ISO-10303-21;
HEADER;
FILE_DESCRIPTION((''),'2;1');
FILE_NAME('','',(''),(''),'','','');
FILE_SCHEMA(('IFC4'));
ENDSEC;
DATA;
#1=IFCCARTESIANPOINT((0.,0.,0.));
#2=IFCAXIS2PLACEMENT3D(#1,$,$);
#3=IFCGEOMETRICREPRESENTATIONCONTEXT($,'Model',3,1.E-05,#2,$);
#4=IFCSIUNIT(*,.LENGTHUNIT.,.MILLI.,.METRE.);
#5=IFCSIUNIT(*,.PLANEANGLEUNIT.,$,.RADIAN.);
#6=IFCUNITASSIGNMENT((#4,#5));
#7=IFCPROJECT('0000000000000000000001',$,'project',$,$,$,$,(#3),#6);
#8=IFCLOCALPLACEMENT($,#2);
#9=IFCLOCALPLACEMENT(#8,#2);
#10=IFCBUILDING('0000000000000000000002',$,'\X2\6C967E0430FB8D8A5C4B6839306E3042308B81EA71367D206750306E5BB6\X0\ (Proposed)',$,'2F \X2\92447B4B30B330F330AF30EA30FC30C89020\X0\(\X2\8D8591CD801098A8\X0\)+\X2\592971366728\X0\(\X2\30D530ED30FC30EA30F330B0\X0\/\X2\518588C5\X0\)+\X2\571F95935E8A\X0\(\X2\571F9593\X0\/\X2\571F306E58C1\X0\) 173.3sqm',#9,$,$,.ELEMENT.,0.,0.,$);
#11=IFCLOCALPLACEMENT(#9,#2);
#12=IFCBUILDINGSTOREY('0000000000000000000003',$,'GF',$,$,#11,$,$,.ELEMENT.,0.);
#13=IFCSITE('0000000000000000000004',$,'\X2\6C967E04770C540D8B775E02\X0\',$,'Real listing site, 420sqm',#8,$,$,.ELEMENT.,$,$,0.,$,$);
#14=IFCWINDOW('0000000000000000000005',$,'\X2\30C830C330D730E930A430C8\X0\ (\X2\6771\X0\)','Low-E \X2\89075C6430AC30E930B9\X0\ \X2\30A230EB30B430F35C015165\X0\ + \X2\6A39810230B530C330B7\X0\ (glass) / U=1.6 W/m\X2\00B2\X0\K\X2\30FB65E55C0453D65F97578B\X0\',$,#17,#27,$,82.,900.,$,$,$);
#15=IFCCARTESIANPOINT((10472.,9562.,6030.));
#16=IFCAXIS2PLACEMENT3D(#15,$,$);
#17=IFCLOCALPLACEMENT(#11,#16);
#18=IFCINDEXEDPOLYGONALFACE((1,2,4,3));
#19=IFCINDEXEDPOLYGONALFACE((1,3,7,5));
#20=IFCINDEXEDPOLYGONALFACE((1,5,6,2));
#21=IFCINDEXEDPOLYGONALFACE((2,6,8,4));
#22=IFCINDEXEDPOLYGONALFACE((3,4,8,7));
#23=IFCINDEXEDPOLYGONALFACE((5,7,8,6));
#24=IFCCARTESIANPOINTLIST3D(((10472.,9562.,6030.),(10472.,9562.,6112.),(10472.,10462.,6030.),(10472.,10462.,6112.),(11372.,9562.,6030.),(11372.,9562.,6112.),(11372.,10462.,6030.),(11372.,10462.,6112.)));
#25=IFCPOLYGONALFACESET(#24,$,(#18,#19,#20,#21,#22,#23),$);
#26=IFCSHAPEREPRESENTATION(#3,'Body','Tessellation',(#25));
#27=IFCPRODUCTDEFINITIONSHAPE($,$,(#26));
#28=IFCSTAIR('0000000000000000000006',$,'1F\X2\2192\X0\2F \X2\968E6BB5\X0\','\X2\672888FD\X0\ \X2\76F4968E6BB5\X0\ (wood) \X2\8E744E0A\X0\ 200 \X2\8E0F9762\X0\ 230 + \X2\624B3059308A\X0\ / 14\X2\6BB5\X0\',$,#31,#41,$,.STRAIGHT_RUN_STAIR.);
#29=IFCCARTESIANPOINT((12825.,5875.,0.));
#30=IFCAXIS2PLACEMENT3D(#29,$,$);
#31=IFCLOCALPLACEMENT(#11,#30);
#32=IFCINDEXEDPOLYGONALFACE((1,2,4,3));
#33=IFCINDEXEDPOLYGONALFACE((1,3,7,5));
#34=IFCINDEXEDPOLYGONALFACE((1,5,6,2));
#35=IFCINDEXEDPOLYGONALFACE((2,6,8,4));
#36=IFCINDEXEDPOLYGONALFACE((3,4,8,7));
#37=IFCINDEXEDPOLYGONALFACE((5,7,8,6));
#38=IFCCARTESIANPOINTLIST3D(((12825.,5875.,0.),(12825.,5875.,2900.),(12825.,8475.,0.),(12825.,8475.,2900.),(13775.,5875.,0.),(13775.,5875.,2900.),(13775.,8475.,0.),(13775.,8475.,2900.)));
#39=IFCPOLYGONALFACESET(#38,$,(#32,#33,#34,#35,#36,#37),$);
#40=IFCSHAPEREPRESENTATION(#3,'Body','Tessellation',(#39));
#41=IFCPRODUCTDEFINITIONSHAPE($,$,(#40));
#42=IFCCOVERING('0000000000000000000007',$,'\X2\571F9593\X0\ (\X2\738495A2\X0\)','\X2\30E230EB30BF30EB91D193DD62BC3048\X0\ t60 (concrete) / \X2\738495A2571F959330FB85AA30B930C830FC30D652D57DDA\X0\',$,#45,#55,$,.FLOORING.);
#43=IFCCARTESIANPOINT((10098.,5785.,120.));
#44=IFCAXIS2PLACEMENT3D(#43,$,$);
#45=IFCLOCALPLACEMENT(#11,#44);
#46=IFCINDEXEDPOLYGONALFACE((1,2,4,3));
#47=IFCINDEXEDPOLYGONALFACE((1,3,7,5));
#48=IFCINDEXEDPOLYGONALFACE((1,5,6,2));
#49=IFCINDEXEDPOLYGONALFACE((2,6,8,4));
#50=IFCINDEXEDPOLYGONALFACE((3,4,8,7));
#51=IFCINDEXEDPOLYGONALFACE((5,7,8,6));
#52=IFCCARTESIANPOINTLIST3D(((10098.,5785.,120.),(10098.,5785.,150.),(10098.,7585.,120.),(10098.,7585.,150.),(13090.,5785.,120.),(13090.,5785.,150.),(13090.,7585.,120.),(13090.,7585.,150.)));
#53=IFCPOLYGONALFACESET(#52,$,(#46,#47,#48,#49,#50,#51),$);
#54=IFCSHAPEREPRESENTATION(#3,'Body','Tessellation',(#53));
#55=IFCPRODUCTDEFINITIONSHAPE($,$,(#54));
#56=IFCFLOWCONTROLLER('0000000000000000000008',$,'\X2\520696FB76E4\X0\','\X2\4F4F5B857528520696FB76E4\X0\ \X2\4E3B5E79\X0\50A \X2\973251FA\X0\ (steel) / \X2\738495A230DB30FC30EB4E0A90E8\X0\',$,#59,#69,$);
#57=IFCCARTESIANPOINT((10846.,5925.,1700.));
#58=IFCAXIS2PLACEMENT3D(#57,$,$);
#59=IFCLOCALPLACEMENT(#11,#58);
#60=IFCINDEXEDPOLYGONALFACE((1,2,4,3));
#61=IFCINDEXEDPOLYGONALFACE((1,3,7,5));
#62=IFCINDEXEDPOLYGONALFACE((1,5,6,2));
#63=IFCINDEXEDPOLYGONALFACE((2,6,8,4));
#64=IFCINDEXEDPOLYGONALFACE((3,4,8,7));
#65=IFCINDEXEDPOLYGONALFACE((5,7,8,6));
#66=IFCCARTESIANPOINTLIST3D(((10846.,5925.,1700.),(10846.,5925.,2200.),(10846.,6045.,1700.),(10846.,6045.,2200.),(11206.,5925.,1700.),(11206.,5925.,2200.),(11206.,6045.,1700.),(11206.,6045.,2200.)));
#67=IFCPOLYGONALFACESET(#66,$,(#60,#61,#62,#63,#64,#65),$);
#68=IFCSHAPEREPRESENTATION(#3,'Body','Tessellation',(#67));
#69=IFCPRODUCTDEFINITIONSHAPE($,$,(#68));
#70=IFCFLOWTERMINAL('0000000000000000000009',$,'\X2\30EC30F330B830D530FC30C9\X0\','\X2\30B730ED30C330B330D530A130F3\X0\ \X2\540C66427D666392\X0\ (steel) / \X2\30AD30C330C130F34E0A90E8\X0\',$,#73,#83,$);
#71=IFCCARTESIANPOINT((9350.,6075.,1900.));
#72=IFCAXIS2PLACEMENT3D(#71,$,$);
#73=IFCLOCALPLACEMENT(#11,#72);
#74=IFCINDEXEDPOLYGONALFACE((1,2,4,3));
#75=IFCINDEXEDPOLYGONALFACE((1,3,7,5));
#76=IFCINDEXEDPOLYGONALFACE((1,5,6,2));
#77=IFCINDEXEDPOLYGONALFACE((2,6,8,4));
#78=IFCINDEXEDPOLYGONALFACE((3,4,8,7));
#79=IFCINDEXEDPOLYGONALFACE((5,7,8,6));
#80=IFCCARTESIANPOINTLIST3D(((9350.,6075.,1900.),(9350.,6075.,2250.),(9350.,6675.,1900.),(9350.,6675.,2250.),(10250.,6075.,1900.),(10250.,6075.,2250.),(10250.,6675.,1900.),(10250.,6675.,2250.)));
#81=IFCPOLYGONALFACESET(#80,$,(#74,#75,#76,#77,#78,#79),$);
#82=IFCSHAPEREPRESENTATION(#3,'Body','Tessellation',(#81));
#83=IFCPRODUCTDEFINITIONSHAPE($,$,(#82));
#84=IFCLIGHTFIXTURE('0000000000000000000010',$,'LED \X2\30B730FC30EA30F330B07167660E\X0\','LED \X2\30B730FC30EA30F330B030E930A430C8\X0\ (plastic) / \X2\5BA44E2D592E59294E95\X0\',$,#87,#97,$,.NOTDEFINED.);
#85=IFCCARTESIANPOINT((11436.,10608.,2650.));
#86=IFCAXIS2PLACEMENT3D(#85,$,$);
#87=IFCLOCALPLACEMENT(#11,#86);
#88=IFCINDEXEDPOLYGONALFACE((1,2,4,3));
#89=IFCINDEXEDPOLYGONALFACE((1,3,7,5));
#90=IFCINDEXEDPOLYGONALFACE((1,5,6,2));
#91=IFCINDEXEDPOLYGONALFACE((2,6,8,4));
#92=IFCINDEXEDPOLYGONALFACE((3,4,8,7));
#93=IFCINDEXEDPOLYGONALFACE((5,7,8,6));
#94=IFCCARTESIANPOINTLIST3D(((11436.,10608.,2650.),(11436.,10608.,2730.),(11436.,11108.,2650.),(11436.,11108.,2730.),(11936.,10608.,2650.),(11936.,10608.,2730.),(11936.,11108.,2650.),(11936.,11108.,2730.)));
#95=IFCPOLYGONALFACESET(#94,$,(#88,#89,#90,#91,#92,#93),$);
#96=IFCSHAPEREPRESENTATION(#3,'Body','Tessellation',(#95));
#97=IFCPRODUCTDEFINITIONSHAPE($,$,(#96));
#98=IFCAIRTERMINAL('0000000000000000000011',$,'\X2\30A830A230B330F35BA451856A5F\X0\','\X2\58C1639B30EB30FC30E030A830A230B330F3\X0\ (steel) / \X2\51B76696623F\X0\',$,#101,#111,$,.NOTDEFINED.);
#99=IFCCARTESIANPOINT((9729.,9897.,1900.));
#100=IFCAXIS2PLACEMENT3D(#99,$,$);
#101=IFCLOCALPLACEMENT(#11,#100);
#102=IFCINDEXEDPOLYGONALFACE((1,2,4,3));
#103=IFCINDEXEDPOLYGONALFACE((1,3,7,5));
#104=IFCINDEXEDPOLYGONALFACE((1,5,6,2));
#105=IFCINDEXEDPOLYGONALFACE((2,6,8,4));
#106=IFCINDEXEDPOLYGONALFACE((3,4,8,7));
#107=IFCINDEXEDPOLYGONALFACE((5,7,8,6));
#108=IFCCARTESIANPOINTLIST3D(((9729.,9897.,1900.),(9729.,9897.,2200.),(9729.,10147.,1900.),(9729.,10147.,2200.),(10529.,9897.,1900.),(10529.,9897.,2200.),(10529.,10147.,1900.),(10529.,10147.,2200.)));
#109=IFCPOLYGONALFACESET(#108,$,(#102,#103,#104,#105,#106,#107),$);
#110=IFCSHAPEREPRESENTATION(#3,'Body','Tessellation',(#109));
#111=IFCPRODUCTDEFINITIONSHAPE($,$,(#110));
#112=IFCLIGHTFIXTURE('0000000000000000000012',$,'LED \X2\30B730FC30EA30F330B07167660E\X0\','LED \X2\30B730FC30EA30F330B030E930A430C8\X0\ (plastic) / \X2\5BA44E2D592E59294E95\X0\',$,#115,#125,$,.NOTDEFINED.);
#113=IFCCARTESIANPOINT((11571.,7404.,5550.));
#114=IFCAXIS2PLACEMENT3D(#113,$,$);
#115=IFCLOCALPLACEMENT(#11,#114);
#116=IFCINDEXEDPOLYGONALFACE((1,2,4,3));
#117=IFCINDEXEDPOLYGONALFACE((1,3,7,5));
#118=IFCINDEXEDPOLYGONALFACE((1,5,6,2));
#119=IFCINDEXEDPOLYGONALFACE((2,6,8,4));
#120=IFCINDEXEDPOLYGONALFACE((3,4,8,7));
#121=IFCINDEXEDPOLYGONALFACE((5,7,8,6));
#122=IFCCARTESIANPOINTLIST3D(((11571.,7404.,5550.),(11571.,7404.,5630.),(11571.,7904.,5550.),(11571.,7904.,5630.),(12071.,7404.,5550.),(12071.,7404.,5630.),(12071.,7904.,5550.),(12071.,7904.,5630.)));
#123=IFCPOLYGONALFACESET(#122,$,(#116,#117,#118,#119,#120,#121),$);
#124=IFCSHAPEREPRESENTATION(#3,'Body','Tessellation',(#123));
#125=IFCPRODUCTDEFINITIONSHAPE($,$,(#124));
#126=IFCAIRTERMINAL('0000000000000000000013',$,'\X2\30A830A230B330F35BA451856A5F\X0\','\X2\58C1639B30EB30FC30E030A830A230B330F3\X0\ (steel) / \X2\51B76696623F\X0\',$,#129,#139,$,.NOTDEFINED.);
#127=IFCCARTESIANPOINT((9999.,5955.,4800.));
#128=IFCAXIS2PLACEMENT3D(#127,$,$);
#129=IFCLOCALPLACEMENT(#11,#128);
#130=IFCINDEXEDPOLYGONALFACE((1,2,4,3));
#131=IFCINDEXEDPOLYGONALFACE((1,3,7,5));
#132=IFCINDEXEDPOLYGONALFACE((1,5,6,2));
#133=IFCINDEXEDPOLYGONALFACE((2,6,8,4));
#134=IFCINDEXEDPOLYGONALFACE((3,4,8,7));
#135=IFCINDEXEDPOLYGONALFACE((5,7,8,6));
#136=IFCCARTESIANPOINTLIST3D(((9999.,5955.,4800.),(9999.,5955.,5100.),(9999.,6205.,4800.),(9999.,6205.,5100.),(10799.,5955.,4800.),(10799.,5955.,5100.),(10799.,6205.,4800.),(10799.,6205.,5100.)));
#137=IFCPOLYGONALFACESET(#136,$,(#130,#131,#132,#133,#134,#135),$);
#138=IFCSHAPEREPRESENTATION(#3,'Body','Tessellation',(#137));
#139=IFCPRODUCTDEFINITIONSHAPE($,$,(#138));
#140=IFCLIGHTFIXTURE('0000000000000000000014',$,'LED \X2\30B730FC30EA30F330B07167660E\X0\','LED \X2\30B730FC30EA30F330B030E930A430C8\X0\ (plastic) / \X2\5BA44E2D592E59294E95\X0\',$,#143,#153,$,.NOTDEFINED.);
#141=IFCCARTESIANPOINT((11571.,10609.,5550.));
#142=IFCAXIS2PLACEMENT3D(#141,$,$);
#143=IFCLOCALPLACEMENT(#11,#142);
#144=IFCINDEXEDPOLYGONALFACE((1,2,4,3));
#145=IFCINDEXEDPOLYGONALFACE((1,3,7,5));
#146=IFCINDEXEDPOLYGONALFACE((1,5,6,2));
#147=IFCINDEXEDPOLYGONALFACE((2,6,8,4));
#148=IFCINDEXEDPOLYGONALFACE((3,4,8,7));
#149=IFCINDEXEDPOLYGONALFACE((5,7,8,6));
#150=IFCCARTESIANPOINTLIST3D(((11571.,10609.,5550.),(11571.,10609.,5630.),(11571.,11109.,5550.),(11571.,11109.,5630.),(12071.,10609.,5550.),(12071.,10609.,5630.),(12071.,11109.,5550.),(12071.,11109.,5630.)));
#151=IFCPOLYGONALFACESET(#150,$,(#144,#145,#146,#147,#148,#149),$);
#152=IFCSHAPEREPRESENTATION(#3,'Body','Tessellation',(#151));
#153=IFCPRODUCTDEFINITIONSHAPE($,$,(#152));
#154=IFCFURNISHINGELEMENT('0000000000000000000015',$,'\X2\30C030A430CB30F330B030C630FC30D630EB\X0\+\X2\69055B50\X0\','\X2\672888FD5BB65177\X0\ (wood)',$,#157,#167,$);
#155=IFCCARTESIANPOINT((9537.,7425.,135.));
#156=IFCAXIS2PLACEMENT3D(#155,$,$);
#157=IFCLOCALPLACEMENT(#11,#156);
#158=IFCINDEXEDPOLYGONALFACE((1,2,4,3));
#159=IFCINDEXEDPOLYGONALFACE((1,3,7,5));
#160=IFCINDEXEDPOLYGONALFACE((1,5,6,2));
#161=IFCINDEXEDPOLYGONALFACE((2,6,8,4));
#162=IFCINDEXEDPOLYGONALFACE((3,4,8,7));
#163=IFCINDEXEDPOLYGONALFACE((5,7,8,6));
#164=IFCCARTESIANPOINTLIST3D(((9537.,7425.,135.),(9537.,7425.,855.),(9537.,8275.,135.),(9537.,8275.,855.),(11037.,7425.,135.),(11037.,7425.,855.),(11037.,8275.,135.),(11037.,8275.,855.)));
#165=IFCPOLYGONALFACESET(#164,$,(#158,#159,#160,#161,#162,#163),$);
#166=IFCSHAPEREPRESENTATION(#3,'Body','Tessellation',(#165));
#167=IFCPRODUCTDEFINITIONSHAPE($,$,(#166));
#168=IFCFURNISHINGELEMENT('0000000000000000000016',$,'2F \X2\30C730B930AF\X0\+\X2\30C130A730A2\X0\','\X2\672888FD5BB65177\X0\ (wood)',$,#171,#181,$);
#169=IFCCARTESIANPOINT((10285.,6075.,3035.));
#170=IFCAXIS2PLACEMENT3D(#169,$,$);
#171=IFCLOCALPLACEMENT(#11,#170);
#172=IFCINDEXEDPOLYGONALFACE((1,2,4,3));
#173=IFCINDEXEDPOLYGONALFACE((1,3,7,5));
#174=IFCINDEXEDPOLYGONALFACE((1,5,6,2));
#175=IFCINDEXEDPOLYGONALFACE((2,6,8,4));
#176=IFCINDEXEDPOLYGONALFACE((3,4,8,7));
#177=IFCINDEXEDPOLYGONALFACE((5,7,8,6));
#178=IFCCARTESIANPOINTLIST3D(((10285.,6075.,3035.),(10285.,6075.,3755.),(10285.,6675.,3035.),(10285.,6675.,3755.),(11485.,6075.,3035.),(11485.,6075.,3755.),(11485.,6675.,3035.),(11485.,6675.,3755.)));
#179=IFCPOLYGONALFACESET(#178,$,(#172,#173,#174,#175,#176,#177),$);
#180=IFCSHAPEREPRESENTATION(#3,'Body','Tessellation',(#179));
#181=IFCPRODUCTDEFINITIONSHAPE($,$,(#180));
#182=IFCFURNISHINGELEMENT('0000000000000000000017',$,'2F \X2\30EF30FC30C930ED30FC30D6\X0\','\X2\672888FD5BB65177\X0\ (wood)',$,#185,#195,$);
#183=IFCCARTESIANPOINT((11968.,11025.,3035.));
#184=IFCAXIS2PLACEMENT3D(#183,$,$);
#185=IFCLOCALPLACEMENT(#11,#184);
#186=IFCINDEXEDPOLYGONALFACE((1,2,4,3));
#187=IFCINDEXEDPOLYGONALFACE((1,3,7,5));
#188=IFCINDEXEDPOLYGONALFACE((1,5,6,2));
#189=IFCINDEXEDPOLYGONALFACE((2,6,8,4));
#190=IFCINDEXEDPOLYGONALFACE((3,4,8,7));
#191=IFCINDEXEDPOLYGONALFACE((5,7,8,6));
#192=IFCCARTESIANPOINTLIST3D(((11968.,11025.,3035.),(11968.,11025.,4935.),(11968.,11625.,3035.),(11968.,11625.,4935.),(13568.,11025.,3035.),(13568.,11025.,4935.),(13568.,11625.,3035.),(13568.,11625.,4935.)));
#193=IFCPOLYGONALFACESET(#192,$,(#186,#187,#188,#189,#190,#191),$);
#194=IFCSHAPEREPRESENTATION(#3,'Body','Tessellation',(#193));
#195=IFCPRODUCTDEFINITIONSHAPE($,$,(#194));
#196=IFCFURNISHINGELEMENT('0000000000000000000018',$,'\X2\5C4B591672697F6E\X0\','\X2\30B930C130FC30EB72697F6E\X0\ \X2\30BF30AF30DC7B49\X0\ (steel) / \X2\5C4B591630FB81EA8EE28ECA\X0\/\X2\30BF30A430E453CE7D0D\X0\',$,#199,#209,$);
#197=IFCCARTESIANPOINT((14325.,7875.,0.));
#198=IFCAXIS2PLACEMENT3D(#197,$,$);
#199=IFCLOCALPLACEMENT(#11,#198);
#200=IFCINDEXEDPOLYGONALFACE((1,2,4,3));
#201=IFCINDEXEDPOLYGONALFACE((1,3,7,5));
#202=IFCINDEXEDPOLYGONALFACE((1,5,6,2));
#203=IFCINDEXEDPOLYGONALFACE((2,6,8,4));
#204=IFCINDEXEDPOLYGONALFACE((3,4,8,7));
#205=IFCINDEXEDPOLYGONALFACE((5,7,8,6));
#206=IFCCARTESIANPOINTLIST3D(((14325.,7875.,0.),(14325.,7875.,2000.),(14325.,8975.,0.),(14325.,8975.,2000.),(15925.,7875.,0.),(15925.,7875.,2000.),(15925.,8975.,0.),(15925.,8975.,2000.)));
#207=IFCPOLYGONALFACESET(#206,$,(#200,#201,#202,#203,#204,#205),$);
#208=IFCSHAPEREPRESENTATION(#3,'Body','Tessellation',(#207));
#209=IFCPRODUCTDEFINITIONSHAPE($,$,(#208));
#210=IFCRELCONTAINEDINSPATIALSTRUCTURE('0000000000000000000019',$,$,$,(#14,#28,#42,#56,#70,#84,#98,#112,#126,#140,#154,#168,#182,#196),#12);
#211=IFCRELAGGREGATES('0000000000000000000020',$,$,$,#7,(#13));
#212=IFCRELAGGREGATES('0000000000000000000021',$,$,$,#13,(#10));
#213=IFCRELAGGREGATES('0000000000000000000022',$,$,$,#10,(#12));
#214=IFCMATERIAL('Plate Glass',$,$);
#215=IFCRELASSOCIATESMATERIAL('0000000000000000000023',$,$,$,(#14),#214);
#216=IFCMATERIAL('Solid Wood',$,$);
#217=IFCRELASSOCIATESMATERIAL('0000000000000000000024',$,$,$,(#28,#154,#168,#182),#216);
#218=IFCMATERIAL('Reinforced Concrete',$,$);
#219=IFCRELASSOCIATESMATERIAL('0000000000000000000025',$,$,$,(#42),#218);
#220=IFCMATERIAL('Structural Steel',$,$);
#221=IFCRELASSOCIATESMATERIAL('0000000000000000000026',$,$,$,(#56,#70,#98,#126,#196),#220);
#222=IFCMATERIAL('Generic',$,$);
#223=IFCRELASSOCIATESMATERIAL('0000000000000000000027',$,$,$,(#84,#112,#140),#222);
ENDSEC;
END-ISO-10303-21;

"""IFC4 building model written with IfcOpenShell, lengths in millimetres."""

from ifc_helpers import new_model, si_unit, frame, frame_2d, origin, place, context, project, spatial, rectangle, extrude, material, element, save


model = new_model("IFC4")

# Units and contexts
model_context = context("Model", 3, precision=1e-05, world=origin())
ifc_project = project(units=[si_unit("LENGTHUNIT", "METRE", prefix="MILLI"), si_unit("PLANEANGLEUNIT", "RADIAN")], contexts=[model_context])

# Site, building, storey
site_placement = place(None, origin())
site = spatial("IfcSite", under=ifc_project, at=site_placement, Name="沖縄県名護市", ObjectType="Real listing site, 420sqm", CompositionType="ELEMENT", RefElevation=0.0)
building_placement = place(site_placement, origin())
building = spatial("IfcBuilding", under=site, at=building_placement, Name="沖縄・越屋根のある自然素材の家 (Proposed)", ObjectType="2F 鉄筋コンクリート造(超重耐風)+天然木(フローリング/内装)+土間床(土間/土の壁) 173.3sqm", CompositionType="ELEMENT", ElevationOfRefHeight=0.0, ElevationOfTerrain=0.0)
storey_placement = place(building_placement, origin())
storey = spatial("IfcBuildingStorey", under=building, at=storey_placement, Name="GF", CompositionType="ELEMENT", Elevation=0.0)

# Shared definitions
ifc_material_1 = material(Name="Solid Wood")

# Window
ifc_material_2 = material(Name="Plate Glass")
window_placement = place(storey_placement, frame((10472.0, 9562.0, 6030.0)))
element("IfcWindow", 1, at=window_placement, inside=storey, material=ifc_material_2, Name="トップライト (東)", Description="Low-E 複層ガラス アルゴン封入 + 樹脂サッシ (glass) / U=1.6 W/m²K・日射取得型", OverallHeight=82.0, OverallWidth=900.0, context=model_context, shape_type="SweptSolid", body=[
    extrude(rectangle(XDim=900.0, YDim=900.0, at=frame_2d((450.0, 450.0))), frame((10472.0, 9562.0, 6030.0)), (0.0, 0.0, 1.0), 82.0),
])

# Stair
stair_placement = place(storey_placement, frame((12825.0, 5875.0, 0.0)))
element("IfcStair", 2, at=stair_placement, inside=storey, material=ifc_material_1, Name="1F→2F 階段", Description="木製 直階段 (wood) 蹴上 200 踏面 230 + 手すり / 14段", PredefinedType="STRAIGHT_RUN_STAIR", context=model_context, shape_type="SweptSolid", body=[
    extrude(rectangle(XDim=950.0, YDim=2600.0, at=frame_2d((475.0, 1300.0))), frame((12825.0, 5875.0, 0.0)), (0.0, 0.0, 1.0), 2900.0),
])

# Covering
ifc_material_3 = material(Name="Reinforced Concrete")
covering_placement = place(storey_placement, frame((10098.0, 5785.0, 120.0)))
element("IfcCovering", 3, at=covering_placement, inside=storey, material=ifc_material_3, Name="土間 (玄関)", Description="モルタル金鏝押え t60 (concrete) / 玄関土間・薪ストーブ動線", PredefinedType="FLOORING", context=model_context, shape_type="SweptSolid", body=[
    extrude(rectangle(XDim=2992.0, YDim=1800.0, at=frame_2d((1496.0, 900.0))), frame((10098.0, 5785.0, 120.0)), (0.0, 0.0, 1.0), 30.0),
])

# Flow controller
ifc_material_4 = material(Name="Structural Steel")
flow_controller_placement = place(storey_placement, frame((10846.0, 5925.0, 1700.0)))
element("IfcFlowController", 4, at=flow_controller_placement, inside=storey, material=ifc_material_4, Name="分電盤", Description="住宅用分電盤 主幹50A 露出 (steel) / 玄関ホール上部", context=model_context, shape_type="SweptSolid", body=[
    extrude(rectangle(XDim=360.0, YDim=120.0, at=frame_2d((180.0, 60.0))), frame((10846.0, 5925.0, 1700.0)), (0.0, 0.0, 1.0), 500.0),
])

# Flow terminal
flow_terminal_placement = place(storey_placement, frame((9350.0, 6075.0, 1900.0)))
element("IfcFlowTerminal", 5, at=flow_terminal_placement, inside=storey, material=ifc_material_4, Name="レンジフード", Description="シロッコファン 同時給排 (steel) / キッチン上部", context=model_context, shape_type="SweptSolid", body=[
    extrude(rectangle(XDim=900.0, YDim=600.0, at=frame_2d((450.0, 300.0))), frame((9350.0, 6075.0, 1900.0)), (0.0, 0.0, 1.0), 350.0),
])

# Light fixture
ifc_material_5 = material(Name="Generic")
light_fixture_1_placement = place(storey_placement, frame((11436.0, 10608.0, 2650.0)))
element("IfcLightFixture", 6, at=light_fixture_1_placement, inside=storey, material=ifc_material_5, Name="LED シーリング照明", Description="LED シーリングライト (plastic) / 室中央天井", PredefinedType="NOTDEFINED", context=model_context, shape_type="SweptSolid", body=[
    extrude(rectangle(XDim=500.0, YDim=500.0, at=frame_2d((250.0, 250.0))), frame((11436.0, 10608.0, 2650.0)), (0.0, 0.0, 1.0), 80.0),
])

# Air terminal
air_terminal_1_placement = place(storey_placement, frame((9729.0, 9897.0, 1900.0)))
element("IfcAirTerminal", 7, at=air_terminal_1_placement, inside=storey, material=ifc_material_4, Name="エアコン室内機", Description="壁掛ルームエアコン (steel) / 冷暖房", PredefinedType="NOTDEFINED", context=model_context, shape_type="SweptSolid", body=[
    extrude(rectangle(XDim=800.0, YDim=250.0, at=frame_2d((400.0, 125.0))), frame((9729.0, 9897.0, 1900.0)), (0.0, 0.0, 1.0), 300.0),
])

# Light fixture
light_fixture_2_placement = place(storey_placement, frame((11571.0, 7404.0, 5550.0)))
element("IfcLightFixture", 8, at=light_fixture_2_placement, inside=storey, material=ifc_material_5, Name="LED シーリング照明", Description="LED シーリングライト (plastic) / 室中央天井", PredefinedType="NOTDEFINED", context=model_context, shape_type="SweptSolid", body=[
    extrude(rectangle(XDim=500.0, YDim=500.0, at=frame_2d((250.0, 250.0))), frame((11571.0, 7404.0, 5550.0)), (0.0, 0.0, 1.0), 80.0),
])

# Air terminal
air_terminal_2_placement = place(storey_placement, frame((9999.0, 5955.0, 4800.0)))
element("IfcAirTerminal", 9, at=air_terminal_2_placement, inside=storey, material=ifc_material_4, Name="エアコン室内機", Description="壁掛ルームエアコン (steel) / 冷暖房", PredefinedType="NOTDEFINED", context=model_context, shape_type="SweptSolid", body=[
    extrude(rectangle(XDim=800.0, YDim=250.0, at=frame_2d((400.0, 125.0))), frame((9999.0, 5955.0, 4800.0)), (0.0, 0.0, 1.0), 300.0),
])

# Light fixture
light_fixture_3_placement = place(storey_placement, frame((11571.0, 10609.0, 5550.0)))
element("IfcLightFixture", 10, at=light_fixture_3_placement, inside=storey, material=ifc_material_5, Name="LED シーリング照明", Description="LED シーリングライト (plastic) / 室中央天井", PredefinedType="NOTDEFINED", context=model_context, shape_type="SweptSolid", body=[
    extrude(rectangle(XDim=500.0, YDim=500.0, at=frame_2d((250.0, 250.0))), frame((11571.0, 10609.0, 5550.0)), (0.0, 0.0, 1.0), 80.0),
])

# Furnishing elements
furnishing_1_placement = place(storey_placement, frame((9537.0, 7425.0, 135.0)))
element("IfcFurnishingElement", 11, at=furnishing_1_placement, inside=storey, material=ifc_material_1, Name="ダイニングテーブル+椅子", Description="木製家具 (wood)", context=model_context, shape_type="SweptSolid", body=[
    extrude(rectangle(XDim=1500.0, YDim=850.0, at=frame_2d((750.0, 425.0))), frame((9537.0, 7425.0, 135.0)), (0.0, 0.0, 1.0), 720.0),
])
furnishing_2_placement = place(storey_placement, frame((10285.0, 6075.0, 3035.0)))
element("IfcFurnishingElement", 12, at=furnishing_2_placement, inside=storey, material=ifc_material_1, Name="2F デスク+チェア", Description="木製家具 (wood)", context=model_context, shape_type="SweptSolid", body=[
    extrude(rectangle(XDim=1200.0, YDim=600.0, at=frame_2d((600.0, 300.0))), frame((10285.0, 6075.0, 3035.0)), (0.0, 0.0, 1.0), 720.0),
])
furnishing_3_placement = place(storey_placement, frame((11968.0, 11025.0, 3035.0)))
element("IfcFurnishingElement", 13, at=furnishing_3_placement, inside=storey, material=ifc_material_1, Name="2F ワードローブ", Description="木製家具 (wood)", context=model_context, shape_type="SweptSolid", body=[
    extrude(rectangle(XDim=1600.0, YDim=600.0, at=frame_2d((800.0, 300.0))), frame((11968.0, 11025.0, 3035.0)), (0.0, 0.0, 1.0), 1900.0),
])
furnishing_4_placement = place(storey_placement, frame((14325.0, 7875.0, 0.0)))
element("IfcFurnishingElement", 14, at=furnishing_4_placement, inside=storey, material=ifc_material_4, Name="屋外物置", Description="スチール物置 タクボ等 (steel) / 屋外・自転車/タイヤ収納", context=model_context, shape_type="SweptSolid", body=[
    extrude(rectangle(XDim=1600.0, YDim=1100.0, at=frame_2d((800.0, 550.0))), frame((14325.0, 7875.0, 0.0)), (0.0, 0.0, 1.0), 2000.0),
])

save(model, "model.ifc")
